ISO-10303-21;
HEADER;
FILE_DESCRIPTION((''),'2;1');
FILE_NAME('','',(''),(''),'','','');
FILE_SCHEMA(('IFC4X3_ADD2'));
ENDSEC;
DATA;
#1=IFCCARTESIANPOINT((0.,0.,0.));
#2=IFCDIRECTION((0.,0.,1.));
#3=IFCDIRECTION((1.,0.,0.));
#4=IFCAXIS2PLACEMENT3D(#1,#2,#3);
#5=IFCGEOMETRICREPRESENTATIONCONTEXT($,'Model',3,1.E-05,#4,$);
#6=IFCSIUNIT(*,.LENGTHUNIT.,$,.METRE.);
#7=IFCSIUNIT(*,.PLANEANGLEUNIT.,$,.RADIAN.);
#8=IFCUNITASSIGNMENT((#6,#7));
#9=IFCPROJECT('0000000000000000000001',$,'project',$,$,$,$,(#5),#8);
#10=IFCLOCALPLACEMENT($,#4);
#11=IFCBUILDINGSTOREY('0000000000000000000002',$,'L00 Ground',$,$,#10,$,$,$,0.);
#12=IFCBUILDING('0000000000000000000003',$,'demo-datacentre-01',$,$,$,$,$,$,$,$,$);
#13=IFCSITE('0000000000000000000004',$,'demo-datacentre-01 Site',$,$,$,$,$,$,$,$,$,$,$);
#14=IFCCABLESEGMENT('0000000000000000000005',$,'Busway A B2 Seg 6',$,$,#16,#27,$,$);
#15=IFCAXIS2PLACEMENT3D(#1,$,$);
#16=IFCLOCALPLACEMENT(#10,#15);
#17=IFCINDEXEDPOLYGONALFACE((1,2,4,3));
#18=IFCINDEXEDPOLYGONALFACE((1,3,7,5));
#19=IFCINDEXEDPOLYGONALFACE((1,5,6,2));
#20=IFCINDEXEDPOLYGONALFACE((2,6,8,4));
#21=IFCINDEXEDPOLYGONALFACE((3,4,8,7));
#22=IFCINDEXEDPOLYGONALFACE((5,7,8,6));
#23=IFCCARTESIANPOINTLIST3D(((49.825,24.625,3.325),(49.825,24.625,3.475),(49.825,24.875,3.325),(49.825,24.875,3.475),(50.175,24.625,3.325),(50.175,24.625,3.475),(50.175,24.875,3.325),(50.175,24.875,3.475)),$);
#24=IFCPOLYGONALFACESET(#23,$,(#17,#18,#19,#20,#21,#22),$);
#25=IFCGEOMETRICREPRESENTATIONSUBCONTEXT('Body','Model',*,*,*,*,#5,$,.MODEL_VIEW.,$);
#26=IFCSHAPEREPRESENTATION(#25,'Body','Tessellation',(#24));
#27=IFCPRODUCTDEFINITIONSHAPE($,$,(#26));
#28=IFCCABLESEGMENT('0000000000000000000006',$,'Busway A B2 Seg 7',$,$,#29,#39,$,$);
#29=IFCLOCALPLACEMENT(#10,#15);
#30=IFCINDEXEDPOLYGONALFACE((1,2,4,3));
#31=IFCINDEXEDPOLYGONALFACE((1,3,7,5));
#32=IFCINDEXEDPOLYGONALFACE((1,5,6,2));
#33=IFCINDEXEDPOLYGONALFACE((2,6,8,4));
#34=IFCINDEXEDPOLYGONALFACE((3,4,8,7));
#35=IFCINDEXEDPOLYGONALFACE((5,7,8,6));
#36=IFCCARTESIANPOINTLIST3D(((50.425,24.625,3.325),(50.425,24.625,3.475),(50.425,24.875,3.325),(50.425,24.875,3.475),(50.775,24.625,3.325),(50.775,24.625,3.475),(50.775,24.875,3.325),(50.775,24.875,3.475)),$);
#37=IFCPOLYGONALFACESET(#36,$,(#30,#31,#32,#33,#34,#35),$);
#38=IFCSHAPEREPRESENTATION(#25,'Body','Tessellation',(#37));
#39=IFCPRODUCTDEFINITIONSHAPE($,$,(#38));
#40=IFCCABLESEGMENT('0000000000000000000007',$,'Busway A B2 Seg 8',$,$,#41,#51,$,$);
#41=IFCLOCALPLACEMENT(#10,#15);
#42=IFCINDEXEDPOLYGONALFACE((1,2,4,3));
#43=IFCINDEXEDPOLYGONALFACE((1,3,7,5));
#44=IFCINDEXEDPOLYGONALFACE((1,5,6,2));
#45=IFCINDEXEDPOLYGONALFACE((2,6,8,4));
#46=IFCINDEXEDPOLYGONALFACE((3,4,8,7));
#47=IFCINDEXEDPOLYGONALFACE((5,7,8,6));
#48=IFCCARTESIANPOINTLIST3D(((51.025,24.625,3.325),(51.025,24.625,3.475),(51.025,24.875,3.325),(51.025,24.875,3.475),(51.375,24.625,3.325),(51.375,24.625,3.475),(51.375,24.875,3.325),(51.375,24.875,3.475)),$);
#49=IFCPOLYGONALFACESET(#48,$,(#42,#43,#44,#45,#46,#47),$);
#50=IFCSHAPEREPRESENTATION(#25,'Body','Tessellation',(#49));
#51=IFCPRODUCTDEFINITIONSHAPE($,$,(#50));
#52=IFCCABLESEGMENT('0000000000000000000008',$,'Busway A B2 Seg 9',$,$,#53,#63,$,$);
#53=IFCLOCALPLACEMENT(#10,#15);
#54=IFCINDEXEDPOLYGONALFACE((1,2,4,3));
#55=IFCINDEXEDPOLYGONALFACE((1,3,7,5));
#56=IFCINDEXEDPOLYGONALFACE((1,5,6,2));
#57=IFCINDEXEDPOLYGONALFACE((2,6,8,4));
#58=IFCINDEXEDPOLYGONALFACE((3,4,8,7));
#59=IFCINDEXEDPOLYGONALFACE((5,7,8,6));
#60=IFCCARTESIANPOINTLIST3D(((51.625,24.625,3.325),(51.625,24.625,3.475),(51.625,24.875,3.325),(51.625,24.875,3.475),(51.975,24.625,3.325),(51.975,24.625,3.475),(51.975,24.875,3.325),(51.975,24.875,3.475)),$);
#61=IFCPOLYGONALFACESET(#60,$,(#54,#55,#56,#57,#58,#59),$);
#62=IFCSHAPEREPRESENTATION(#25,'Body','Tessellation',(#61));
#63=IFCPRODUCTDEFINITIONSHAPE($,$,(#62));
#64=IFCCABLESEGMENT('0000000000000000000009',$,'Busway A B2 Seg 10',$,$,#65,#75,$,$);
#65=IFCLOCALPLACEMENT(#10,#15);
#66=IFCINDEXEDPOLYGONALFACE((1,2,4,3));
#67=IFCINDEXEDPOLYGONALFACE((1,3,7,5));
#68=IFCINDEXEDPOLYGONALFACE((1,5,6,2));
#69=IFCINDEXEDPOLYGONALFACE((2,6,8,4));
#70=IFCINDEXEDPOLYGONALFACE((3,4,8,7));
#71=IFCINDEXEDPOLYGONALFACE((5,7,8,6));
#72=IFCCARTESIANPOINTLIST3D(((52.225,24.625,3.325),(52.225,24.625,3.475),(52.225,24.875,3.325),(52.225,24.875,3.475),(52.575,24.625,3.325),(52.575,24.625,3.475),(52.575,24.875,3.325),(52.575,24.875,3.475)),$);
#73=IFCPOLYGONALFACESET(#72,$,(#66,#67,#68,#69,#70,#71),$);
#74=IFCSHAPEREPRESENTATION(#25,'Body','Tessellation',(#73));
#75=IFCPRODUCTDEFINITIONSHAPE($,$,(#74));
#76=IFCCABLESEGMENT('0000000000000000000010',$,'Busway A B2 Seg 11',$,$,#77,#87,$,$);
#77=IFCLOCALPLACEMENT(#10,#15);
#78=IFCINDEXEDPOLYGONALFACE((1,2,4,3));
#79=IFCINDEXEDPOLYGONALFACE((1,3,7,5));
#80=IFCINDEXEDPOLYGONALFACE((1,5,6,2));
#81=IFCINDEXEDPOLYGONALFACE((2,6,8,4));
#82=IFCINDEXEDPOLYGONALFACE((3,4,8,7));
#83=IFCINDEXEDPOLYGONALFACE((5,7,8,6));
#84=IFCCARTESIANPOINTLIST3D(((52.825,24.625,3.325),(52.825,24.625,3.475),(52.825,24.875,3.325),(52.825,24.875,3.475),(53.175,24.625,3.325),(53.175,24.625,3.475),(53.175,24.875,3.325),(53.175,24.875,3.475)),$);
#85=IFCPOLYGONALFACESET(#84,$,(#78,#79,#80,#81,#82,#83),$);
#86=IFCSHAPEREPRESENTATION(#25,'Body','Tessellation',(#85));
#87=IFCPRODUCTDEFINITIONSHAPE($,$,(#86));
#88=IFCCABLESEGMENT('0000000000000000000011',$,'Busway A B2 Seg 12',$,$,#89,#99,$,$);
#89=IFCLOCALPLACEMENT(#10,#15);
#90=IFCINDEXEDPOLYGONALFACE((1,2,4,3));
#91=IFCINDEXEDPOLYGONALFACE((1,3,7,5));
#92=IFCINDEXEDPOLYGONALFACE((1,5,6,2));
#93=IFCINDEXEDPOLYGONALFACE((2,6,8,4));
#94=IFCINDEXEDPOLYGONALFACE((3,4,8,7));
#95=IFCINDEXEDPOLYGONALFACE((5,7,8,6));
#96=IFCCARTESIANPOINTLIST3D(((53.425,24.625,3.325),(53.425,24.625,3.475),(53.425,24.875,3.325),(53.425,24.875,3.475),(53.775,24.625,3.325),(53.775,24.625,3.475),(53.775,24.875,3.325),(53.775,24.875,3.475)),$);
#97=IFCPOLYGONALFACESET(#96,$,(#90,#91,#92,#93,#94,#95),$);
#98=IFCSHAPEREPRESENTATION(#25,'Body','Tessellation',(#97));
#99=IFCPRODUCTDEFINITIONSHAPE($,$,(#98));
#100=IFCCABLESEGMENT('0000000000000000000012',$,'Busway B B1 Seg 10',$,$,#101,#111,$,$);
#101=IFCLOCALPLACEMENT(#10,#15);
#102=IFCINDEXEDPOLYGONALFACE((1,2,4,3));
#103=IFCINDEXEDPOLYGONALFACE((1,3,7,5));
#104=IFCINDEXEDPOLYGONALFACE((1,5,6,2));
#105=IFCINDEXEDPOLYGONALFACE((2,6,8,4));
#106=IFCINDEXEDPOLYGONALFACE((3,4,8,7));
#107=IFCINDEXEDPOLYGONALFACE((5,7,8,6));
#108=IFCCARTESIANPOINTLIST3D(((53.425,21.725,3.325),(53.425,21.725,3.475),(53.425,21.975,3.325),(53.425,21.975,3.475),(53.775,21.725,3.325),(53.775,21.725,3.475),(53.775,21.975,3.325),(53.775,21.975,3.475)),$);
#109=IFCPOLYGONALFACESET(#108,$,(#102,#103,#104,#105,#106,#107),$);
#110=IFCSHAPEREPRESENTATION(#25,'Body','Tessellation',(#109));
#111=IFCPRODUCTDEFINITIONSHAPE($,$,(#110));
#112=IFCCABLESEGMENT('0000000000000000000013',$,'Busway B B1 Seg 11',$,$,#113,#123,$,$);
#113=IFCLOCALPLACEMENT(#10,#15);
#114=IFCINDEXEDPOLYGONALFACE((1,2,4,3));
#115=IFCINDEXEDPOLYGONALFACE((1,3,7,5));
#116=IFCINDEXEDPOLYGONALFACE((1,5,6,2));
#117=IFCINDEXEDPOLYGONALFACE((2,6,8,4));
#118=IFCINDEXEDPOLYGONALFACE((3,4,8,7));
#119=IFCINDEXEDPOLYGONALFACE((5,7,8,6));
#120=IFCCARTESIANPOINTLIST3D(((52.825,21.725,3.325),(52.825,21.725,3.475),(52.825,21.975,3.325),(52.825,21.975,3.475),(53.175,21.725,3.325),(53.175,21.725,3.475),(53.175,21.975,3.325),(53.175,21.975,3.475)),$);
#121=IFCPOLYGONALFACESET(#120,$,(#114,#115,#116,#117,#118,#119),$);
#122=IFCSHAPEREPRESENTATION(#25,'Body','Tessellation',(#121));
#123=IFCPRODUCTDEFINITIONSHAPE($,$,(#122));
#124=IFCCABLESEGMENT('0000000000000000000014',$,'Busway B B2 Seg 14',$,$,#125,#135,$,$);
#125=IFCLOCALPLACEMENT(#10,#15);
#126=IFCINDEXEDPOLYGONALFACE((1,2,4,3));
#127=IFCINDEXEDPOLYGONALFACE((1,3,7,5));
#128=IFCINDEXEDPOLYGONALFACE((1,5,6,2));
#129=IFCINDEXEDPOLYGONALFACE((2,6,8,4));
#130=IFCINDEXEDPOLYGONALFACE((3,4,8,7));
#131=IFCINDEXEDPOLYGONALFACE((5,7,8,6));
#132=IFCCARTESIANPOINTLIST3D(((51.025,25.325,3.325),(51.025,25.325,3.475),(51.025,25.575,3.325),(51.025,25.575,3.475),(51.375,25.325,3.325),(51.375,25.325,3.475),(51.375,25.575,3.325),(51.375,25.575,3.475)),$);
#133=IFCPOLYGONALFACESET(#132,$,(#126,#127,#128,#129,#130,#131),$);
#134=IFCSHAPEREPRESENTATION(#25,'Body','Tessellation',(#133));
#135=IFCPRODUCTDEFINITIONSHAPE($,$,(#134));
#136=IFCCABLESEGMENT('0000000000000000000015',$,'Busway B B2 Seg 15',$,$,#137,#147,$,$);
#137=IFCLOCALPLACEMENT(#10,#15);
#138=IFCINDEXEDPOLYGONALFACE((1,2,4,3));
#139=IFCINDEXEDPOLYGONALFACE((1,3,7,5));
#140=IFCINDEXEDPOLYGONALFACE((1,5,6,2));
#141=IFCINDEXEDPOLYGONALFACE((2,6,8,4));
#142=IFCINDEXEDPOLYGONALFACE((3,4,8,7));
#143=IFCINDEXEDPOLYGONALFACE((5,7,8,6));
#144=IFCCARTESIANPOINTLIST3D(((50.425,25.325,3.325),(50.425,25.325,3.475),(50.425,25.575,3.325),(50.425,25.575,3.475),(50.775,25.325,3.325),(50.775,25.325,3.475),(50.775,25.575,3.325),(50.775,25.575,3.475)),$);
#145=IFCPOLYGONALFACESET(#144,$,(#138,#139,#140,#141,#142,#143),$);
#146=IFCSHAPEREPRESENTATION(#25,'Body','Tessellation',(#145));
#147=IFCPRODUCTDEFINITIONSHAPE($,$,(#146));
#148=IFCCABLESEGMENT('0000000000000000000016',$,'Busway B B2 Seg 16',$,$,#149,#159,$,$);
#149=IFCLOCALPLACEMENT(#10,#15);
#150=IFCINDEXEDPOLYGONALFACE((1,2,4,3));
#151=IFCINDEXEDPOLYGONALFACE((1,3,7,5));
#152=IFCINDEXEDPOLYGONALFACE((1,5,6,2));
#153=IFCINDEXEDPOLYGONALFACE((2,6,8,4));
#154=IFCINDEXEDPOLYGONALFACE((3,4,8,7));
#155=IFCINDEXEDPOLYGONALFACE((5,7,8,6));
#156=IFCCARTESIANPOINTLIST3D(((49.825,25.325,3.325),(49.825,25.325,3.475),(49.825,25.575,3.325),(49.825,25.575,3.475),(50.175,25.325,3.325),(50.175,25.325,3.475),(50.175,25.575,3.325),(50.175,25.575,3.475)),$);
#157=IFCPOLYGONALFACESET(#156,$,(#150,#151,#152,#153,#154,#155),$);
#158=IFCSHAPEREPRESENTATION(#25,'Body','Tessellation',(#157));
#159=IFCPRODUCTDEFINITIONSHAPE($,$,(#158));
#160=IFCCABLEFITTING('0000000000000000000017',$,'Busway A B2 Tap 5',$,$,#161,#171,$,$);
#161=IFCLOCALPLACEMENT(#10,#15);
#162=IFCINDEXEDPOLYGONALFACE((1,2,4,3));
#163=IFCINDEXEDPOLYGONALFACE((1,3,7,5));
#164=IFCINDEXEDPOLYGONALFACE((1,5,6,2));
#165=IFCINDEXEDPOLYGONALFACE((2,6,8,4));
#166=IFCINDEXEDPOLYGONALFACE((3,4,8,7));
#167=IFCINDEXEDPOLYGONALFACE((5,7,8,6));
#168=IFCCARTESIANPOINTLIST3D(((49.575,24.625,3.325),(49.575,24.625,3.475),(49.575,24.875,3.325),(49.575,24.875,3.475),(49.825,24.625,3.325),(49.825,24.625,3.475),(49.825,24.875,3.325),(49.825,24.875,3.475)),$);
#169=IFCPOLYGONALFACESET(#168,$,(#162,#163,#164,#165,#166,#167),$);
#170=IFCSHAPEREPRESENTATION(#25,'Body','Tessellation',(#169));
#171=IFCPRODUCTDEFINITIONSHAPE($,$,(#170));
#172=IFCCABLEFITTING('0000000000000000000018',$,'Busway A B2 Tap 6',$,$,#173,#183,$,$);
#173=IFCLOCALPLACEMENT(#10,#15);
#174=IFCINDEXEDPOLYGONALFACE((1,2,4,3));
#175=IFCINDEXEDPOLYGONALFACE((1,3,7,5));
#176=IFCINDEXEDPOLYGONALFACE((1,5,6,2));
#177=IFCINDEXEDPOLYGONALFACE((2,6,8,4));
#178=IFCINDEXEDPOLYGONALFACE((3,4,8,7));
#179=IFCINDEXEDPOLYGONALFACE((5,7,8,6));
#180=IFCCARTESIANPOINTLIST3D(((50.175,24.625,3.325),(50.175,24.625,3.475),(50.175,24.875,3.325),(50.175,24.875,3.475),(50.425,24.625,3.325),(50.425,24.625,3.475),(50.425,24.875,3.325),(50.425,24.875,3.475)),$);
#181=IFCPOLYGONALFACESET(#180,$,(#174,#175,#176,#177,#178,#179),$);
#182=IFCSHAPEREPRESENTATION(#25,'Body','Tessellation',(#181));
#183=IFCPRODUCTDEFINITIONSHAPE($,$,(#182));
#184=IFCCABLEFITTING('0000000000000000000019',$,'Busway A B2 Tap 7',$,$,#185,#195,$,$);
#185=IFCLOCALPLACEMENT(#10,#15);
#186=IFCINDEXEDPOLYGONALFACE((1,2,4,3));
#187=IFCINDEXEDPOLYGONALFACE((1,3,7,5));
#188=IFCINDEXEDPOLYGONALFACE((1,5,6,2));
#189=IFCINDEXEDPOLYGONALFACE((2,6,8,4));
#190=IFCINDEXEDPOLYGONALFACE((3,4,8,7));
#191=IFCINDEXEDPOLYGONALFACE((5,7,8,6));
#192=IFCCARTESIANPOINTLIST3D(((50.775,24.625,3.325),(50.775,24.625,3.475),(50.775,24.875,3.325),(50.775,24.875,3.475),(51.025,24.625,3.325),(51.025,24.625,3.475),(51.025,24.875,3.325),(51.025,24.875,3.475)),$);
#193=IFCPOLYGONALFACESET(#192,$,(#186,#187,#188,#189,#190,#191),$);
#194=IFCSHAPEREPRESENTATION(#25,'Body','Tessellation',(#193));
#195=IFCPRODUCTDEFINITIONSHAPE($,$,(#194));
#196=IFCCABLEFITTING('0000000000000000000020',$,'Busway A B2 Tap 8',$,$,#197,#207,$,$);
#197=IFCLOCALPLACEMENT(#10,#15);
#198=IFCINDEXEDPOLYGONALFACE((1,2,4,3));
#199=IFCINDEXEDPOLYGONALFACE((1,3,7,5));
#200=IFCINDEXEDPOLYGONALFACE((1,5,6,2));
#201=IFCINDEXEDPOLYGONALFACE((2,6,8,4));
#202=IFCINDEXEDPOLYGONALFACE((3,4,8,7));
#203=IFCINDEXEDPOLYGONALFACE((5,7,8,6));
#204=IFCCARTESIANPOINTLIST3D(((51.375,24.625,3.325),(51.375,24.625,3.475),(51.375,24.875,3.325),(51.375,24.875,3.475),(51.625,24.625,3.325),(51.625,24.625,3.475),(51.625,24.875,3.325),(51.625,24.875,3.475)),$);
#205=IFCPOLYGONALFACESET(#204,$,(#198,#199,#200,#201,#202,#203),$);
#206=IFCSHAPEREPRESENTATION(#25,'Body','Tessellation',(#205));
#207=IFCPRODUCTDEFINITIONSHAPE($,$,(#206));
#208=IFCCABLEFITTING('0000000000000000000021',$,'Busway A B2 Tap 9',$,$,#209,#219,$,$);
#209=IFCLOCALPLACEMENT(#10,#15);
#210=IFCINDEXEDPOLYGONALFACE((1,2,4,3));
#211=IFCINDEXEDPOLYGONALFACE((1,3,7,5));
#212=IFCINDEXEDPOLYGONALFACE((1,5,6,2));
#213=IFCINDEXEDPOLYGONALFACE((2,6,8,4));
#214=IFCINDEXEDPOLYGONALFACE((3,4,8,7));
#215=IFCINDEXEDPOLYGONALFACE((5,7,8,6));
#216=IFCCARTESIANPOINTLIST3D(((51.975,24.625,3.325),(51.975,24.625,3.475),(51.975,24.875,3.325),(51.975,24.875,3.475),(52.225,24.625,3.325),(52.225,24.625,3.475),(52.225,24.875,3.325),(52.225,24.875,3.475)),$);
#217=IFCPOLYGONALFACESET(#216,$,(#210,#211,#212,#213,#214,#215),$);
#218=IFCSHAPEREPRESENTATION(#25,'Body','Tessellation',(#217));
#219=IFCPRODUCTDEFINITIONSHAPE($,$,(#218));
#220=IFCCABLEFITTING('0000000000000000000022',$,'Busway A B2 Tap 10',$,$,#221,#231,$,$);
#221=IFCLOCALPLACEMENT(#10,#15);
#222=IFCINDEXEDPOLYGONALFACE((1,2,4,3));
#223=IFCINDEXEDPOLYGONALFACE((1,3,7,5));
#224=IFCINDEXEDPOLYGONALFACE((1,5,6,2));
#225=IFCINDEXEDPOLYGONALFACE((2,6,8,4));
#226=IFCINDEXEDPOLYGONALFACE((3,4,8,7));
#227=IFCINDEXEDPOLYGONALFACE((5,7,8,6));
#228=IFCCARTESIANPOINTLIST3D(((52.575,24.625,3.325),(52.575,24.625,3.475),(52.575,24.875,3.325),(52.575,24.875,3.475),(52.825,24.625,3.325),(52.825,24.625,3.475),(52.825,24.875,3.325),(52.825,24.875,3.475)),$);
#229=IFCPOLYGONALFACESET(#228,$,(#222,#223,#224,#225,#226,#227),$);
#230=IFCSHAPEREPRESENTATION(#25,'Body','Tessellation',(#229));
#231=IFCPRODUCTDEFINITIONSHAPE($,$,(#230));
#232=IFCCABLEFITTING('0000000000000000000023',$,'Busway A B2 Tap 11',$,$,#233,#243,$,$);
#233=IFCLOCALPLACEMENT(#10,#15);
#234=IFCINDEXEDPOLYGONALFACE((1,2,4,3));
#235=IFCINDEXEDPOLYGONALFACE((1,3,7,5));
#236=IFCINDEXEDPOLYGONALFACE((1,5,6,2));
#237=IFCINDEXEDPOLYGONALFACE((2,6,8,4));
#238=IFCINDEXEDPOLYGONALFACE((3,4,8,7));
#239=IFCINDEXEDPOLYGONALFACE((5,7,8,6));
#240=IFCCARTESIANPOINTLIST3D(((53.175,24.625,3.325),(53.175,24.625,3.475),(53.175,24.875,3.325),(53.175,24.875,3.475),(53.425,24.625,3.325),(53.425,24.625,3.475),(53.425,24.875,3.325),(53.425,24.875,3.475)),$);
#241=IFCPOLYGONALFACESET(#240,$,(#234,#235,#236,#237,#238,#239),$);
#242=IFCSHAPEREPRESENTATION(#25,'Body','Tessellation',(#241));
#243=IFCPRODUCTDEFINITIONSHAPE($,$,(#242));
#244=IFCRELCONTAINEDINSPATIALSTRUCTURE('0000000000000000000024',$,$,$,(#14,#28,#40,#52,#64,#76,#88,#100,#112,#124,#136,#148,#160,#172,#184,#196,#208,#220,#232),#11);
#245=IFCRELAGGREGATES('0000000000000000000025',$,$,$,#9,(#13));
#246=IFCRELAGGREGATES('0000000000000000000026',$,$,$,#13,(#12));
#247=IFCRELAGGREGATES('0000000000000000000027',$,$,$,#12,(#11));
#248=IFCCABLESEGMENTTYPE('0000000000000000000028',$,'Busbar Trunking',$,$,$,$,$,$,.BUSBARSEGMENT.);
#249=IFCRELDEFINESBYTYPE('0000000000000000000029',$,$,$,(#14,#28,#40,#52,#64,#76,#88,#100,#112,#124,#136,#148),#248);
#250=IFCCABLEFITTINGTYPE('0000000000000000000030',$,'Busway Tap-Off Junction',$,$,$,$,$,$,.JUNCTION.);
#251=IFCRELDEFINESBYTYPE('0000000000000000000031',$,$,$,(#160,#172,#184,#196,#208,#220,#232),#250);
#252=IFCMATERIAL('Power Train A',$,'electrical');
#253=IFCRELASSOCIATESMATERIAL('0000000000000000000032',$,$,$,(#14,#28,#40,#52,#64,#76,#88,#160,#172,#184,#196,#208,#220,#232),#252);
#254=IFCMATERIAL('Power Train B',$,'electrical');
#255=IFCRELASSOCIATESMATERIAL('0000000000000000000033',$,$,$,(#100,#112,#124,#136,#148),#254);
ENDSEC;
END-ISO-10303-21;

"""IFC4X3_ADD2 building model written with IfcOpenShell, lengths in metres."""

from ifc_helpers import new_model, si_unit, frame, origin_with_axes, place, context, subcontext, project, spatial, rectangle, extrude, material, type_object, element, save


model = new_model("IFC4X3_ADD2")

# Units and contexts
model_context = context("Model", 3, precision=1e-05, world=origin_with_axes())
body_context = subcontext(model_context, "Body", "Model", "MODEL_VIEW")
ifc_project = project(units=[si_unit("LENGTHUNIT", "METRE"), si_unit("PLANEANGLEUNIT", "RADIAN")], contexts=[model_context])

# Site, building, storey
site = spatial("IfcSite", under=ifc_project, Name="demo-datacentre-01 Site")
building = spatial("IfcBuilding", under=site, Name="demo-datacentre-01")
storey_placement = place(None, origin_with_axes())
storey = spatial("IfcBuildingStorey", under=building, at=storey_placement, Name="L00 Ground", Elevation=0.0)

# Cable segments
ifc_material_1 = material(Name="Power Train A", Category="electrical")
cable_segment_type_1 = type_object("IfcCableSegmentType", Name="Busbar Trunking", PredefinedType="BUSBARSEGMENT")
for number, where, z_axis, x_axis, name in (
    (1, (49.825, 24.75, 3.4), (1.0, 0.0, 0.0), (0.0, 1.0, 0.0), "Busway A B2 Seg 6"),
    (2, (50.425, 24.75, 3.4), (1.0, 0.0, 0.0), (0.0, 1.0, 0.0), "Busway A B2 Seg 7"),
    (3, (51.025, 24.75, 3.4), (1.0, 0.0, 0.0), (0.0, 1.0, 0.0), "Busway A B2 Seg 8"),
):
    element("IfcCableSegment", number, at=place(storey_placement, frame(where, z_axis=z_axis, x_axis=x_axis)), inside=storey, type_object=cable_segment_type_1, material=ifc_material_1, Name=name, context=body_context, shape_type="SweptSolid", body=[
        extrude(rectangle(XDim=0.25, YDim=0.15), origin_with_axes(), (0.0, 0.0, 1.0), 0.35),
    ])
cable_segment_placement = place(storey_placement, frame((51.625, 24.75, 3.4), z_axis=(1.0, 0.0, 0.0), x_axis=(0.0, 1.0, 0.0)))
element("IfcCableSegment", 4, at=cable_segment_placement, inside=storey, type_object=cable_segment_type_1, material=ifc_material_1, Name="Busway A B2 Seg 9", context=body_context, shape_type="SweptSolid", body=[
    extrude(rectangle(XDim=0.25, YDim=0.15), origin_with_axes(), (0.0, 0.0, 1.0), 0.35),
])
for number, where, z_axis, x_axis, name in (
    (5, (52.225, 24.75, 3.4), (1.0, 0.0, 0.0), (0.0, 1.0, 0.0), "Busway A B2 Seg 10"),
    (6, (52.825, 24.75, 3.4), (1.0, 0.0, 0.0), (0.0, 1.0, 0.0), "Busway A B2 Seg 11"),
    (7, (53.425, 24.75, 3.4), (1.0, 0.0, 0.0), (0.0, 1.0, 0.0), "Busway A B2 Seg 12"),
):
    element("IfcCableSegment", number, at=place(storey_placement, frame(where, z_axis=z_axis, x_axis=x_axis)), inside=storey, type_object=cable_segment_type_1, material=ifc_material_1, Name=name, context=body_context, shape_type="SweptSolid", body=[
        extrude(rectangle(XDim=0.25, YDim=0.15), origin_with_axes(), (0.0, 0.0, 1.0), 0.35),
    ])
ifc_material_2 = material(Name="Power Train B", Category="electrical")
for number, where, z_axis, x_axis, name in (
    (8, (53.775, 21.85, 3.4), (-1.0, 0.0, 0.0), (0.0, -1.0, 0.0), "Busway B B1 Seg 10"),
    (9, (53.175, 21.85, 3.4), (-1.0, 0.0, 0.0), (0.0, -1.0, 0.0), "Busway B B1 Seg 11"),
    (10, (51.375, 25.45, 3.4), (-1.0, 0.0, 0.0), (0.0, -1.0, 0.0), "Busway B B2 Seg 14"),
    (11, (50.775, 25.45, 3.4), (-1.0, 0.0, 0.0), (0.0, -1.0, 0.0), "Busway B B2 Seg 15"),
    (12, (50.175, 25.45, 3.4), (-1.0, 0.0, 0.0), (0.0, -1.0, 0.0), "Busway B B2 Seg 16"),
):
    element("IfcCableSegment", number, at=place(storey_placement, frame(where, z_axis=z_axis, x_axis=x_axis)), inside=storey, type_object=cable_segment_type_1, material=ifc_material_2, Name=name, context=body_context, shape_type="SweptSolid", body=[
        extrude(rectangle(XDim=0.25, YDim=0.15), origin_with_axes(), (0.0, 0.0, 1.0), 0.35),
    ])

# Cable fittings
cable_fitting_type = type_object("IfcCableFittingType", Name="Busway Tap-Off Junction", PredefinedType="JUNCTION")
for number, where, z_axis, x_axis, name in (
    (13, (49.7, 24.75, 3.325), (0.0, 0.0, 1.0), (1.0, 0.0, 0.0), "Busway A B2 Tap 5"),
    (14, (50.3, 24.75, 3.325), (0.0, 0.0, 1.0), (1.0, 0.0, 0.0), "Busway A B2 Tap 6"),
    (15, (50.9, 24.75, 3.325), (0.0, 0.0, 1.0), (1.0, 0.0, 0.0), "Busway A B2 Tap 7"),
    (16, (51.5, 24.75, 3.325), (0.0, 0.0, 1.0), (1.0, 0.0, 0.0), "Busway A B2 Tap 8"),
    (17, (52.1, 24.75, 3.325), (0.0, 0.0, 1.0), (1.0, 0.0, 0.0), "Busway A B2 Tap 9"),
    (18, (52.7, 24.75, 3.325), (0.0, 0.0, 1.0), (1.0, 0.0, 0.0), "Busway A B2 Tap 10"),
    (19, (53.3, 24.75, 3.325), (0.0, 0.0, 1.0), (1.0, 0.0, 0.0), "Busway A B2 Tap 11"),
):
    element("IfcCableFitting", number, at=place(storey_placement, frame(where, z_axis=z_axis, x_axis=x_axis)), inside=storey, type_object=cable_fitting_type, material=ifc_material_1, Name=name, context=body_context, shape_type="SweptSolid", body=[
        extrude(rectangle(XDim=0.25, YDim=0.25), origin_with_axes(), (0.0, 0.0, 1.0), 0.15),
    ])

save(model, "model.ifc")
